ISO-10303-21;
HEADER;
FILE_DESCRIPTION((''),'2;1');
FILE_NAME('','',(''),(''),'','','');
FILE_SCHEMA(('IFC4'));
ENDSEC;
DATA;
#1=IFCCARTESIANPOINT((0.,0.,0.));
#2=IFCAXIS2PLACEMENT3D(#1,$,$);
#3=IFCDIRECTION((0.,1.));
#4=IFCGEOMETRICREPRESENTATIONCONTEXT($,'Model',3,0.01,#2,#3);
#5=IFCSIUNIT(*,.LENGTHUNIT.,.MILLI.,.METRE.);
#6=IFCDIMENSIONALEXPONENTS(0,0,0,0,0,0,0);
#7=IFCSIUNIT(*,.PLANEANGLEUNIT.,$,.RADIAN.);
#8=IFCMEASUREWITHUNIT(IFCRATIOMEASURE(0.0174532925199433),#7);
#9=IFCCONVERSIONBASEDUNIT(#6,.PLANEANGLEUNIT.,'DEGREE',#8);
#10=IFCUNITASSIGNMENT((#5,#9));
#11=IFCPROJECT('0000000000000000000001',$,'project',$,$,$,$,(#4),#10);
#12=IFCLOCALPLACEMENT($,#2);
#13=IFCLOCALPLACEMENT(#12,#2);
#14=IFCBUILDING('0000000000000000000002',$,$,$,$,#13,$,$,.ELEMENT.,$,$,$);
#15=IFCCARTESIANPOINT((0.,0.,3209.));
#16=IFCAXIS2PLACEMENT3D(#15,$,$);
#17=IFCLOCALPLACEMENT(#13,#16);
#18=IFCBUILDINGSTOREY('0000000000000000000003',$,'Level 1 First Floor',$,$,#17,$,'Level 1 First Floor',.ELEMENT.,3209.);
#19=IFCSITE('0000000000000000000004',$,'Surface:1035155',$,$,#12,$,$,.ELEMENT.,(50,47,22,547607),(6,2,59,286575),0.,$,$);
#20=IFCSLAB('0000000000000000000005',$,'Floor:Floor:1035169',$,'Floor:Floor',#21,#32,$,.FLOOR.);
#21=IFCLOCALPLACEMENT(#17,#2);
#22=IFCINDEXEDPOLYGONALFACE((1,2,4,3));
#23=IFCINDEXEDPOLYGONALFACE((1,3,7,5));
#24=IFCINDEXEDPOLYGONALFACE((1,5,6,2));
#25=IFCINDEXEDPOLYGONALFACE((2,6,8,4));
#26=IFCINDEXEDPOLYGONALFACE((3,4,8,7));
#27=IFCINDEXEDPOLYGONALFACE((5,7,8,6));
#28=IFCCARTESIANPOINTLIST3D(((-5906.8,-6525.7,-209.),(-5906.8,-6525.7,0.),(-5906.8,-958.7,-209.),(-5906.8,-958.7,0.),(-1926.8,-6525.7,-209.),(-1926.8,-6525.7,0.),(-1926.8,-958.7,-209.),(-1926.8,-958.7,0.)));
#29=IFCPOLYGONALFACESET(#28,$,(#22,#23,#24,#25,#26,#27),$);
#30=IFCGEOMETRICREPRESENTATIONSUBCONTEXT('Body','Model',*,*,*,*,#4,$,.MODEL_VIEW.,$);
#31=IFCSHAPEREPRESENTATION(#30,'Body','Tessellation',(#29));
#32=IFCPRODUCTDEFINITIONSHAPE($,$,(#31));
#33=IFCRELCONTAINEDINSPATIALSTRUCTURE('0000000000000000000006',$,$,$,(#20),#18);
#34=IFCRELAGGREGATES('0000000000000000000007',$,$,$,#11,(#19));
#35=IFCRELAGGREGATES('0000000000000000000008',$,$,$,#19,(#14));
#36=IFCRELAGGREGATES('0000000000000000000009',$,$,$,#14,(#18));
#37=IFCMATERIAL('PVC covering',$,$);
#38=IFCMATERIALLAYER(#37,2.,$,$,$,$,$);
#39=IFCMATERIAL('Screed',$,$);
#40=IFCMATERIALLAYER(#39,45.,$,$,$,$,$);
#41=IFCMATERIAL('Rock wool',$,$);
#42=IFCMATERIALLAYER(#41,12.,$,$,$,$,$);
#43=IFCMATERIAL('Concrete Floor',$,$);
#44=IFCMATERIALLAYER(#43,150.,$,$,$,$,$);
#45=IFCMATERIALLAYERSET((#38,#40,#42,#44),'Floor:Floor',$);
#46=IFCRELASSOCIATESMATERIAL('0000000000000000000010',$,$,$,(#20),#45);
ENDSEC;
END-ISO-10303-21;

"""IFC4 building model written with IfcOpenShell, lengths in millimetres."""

from ifc_helpers import new_model, entity, si_unit, converted_unit, direction, frame, frame_2d, origin, place, context, subcontext, project, spatial, rectangle, extrude, material, layer, layer_set, layer_usage, element, save


model = new_model("IFC4")

# Units and contexts
model_context = context("Model", 3, precision=0.01, world=origin(), true_north=direction((0.0, 1.0)))
body_context = subcontext(model_context, "Body", "Model", "MODEL_VIEW")
ifc_project = project(units=[si_unit("LENGTHUNIT", "METRE", prefix="MILLI"), converted_unit("PLANEANGLEUNIT", "DEGREE", entity("IfcRatioMeasure", 0.0174532925199433), si_unit("PLANEANGLEUNIT", "RADIAN"), dimensions=[0, 0, 0, 0, 0, 0, 0])], contexts=[model_context])

# Site, building, storey
site_placement = place(None, origin())
site = spatial("IfcSite", under=ifc_project, at=site_placement, Name="Surface:1035155", CompositionType="ELEMENT", RefLatitude=(50, 47, 22, 547607), RefLongitude=(6, 2, 59, 286575), RefElevation=0.0)
building_placement = place(site_placement, origin())
building = spatial("IfcBuilding", under=site, at=building_placement, CompositionType="ELEMENT")
storey_placement = place(building_placement, frame((0.0, 0.0, 3209.0)))
storey = spatial("IfcBuildingStorey", under=building, at=storey_placement, Name="Level 1 First Floor", LongName="Level 1 First Floor", CompositionType="ELEMENT", Elevation=3209.0)

# Slab
ifc_material_1 = material(Name="PVC covering")
ifc_layer_1 = layer(ifc_material_1, 2.0)
ifc_material_2 = material(Name="Screed")
ifc_layer_2 = layer(ifc_material_2, 45.0)
ifc_material_3 = material(Name="Rock wool")
ifc_layer_3 = layer(ifc_material_3, 12.0)
ifc_material_4 = material(Name="Concrete Floor")
ifc_layer_4 = layer(ifc_material_4, 150.0)
ifc_layer_set = layer_set([ifc_layer_1, ifc_layer_2, ifc_layer_3, ifc_layer_4], Name="Floor:Floor")
ifc_layer_usage = layer_usage(ifc_layer_set, "AXIS3", "POSITIVE", 0.0)
slab_placement = place(storey_placement, origin())
element("IfcSlab", 1, at=slab_placement, inside=storey, material=ifc_layer_usage, Name="Floor:Floor:1035169", ObjectType="Floor:Floor", PredefinedType="FLOOR", context=body_context, shape_type="SweptSolid", body=[
    extrude(rectangle(XDim=5567.0, YDim=3980.0, at=frame_2d((0.0, 0.0), x_axis=(1.0, 0.0))), frame((-3916.8, -3742.2, 0.0), z_axis=(0.0, 0.0, -1.0), x_axis=(0.0, 1.0, 0.0)), (0.0, 0.0, 1.0), 209.0),
])

save(model, "model.ifc")
